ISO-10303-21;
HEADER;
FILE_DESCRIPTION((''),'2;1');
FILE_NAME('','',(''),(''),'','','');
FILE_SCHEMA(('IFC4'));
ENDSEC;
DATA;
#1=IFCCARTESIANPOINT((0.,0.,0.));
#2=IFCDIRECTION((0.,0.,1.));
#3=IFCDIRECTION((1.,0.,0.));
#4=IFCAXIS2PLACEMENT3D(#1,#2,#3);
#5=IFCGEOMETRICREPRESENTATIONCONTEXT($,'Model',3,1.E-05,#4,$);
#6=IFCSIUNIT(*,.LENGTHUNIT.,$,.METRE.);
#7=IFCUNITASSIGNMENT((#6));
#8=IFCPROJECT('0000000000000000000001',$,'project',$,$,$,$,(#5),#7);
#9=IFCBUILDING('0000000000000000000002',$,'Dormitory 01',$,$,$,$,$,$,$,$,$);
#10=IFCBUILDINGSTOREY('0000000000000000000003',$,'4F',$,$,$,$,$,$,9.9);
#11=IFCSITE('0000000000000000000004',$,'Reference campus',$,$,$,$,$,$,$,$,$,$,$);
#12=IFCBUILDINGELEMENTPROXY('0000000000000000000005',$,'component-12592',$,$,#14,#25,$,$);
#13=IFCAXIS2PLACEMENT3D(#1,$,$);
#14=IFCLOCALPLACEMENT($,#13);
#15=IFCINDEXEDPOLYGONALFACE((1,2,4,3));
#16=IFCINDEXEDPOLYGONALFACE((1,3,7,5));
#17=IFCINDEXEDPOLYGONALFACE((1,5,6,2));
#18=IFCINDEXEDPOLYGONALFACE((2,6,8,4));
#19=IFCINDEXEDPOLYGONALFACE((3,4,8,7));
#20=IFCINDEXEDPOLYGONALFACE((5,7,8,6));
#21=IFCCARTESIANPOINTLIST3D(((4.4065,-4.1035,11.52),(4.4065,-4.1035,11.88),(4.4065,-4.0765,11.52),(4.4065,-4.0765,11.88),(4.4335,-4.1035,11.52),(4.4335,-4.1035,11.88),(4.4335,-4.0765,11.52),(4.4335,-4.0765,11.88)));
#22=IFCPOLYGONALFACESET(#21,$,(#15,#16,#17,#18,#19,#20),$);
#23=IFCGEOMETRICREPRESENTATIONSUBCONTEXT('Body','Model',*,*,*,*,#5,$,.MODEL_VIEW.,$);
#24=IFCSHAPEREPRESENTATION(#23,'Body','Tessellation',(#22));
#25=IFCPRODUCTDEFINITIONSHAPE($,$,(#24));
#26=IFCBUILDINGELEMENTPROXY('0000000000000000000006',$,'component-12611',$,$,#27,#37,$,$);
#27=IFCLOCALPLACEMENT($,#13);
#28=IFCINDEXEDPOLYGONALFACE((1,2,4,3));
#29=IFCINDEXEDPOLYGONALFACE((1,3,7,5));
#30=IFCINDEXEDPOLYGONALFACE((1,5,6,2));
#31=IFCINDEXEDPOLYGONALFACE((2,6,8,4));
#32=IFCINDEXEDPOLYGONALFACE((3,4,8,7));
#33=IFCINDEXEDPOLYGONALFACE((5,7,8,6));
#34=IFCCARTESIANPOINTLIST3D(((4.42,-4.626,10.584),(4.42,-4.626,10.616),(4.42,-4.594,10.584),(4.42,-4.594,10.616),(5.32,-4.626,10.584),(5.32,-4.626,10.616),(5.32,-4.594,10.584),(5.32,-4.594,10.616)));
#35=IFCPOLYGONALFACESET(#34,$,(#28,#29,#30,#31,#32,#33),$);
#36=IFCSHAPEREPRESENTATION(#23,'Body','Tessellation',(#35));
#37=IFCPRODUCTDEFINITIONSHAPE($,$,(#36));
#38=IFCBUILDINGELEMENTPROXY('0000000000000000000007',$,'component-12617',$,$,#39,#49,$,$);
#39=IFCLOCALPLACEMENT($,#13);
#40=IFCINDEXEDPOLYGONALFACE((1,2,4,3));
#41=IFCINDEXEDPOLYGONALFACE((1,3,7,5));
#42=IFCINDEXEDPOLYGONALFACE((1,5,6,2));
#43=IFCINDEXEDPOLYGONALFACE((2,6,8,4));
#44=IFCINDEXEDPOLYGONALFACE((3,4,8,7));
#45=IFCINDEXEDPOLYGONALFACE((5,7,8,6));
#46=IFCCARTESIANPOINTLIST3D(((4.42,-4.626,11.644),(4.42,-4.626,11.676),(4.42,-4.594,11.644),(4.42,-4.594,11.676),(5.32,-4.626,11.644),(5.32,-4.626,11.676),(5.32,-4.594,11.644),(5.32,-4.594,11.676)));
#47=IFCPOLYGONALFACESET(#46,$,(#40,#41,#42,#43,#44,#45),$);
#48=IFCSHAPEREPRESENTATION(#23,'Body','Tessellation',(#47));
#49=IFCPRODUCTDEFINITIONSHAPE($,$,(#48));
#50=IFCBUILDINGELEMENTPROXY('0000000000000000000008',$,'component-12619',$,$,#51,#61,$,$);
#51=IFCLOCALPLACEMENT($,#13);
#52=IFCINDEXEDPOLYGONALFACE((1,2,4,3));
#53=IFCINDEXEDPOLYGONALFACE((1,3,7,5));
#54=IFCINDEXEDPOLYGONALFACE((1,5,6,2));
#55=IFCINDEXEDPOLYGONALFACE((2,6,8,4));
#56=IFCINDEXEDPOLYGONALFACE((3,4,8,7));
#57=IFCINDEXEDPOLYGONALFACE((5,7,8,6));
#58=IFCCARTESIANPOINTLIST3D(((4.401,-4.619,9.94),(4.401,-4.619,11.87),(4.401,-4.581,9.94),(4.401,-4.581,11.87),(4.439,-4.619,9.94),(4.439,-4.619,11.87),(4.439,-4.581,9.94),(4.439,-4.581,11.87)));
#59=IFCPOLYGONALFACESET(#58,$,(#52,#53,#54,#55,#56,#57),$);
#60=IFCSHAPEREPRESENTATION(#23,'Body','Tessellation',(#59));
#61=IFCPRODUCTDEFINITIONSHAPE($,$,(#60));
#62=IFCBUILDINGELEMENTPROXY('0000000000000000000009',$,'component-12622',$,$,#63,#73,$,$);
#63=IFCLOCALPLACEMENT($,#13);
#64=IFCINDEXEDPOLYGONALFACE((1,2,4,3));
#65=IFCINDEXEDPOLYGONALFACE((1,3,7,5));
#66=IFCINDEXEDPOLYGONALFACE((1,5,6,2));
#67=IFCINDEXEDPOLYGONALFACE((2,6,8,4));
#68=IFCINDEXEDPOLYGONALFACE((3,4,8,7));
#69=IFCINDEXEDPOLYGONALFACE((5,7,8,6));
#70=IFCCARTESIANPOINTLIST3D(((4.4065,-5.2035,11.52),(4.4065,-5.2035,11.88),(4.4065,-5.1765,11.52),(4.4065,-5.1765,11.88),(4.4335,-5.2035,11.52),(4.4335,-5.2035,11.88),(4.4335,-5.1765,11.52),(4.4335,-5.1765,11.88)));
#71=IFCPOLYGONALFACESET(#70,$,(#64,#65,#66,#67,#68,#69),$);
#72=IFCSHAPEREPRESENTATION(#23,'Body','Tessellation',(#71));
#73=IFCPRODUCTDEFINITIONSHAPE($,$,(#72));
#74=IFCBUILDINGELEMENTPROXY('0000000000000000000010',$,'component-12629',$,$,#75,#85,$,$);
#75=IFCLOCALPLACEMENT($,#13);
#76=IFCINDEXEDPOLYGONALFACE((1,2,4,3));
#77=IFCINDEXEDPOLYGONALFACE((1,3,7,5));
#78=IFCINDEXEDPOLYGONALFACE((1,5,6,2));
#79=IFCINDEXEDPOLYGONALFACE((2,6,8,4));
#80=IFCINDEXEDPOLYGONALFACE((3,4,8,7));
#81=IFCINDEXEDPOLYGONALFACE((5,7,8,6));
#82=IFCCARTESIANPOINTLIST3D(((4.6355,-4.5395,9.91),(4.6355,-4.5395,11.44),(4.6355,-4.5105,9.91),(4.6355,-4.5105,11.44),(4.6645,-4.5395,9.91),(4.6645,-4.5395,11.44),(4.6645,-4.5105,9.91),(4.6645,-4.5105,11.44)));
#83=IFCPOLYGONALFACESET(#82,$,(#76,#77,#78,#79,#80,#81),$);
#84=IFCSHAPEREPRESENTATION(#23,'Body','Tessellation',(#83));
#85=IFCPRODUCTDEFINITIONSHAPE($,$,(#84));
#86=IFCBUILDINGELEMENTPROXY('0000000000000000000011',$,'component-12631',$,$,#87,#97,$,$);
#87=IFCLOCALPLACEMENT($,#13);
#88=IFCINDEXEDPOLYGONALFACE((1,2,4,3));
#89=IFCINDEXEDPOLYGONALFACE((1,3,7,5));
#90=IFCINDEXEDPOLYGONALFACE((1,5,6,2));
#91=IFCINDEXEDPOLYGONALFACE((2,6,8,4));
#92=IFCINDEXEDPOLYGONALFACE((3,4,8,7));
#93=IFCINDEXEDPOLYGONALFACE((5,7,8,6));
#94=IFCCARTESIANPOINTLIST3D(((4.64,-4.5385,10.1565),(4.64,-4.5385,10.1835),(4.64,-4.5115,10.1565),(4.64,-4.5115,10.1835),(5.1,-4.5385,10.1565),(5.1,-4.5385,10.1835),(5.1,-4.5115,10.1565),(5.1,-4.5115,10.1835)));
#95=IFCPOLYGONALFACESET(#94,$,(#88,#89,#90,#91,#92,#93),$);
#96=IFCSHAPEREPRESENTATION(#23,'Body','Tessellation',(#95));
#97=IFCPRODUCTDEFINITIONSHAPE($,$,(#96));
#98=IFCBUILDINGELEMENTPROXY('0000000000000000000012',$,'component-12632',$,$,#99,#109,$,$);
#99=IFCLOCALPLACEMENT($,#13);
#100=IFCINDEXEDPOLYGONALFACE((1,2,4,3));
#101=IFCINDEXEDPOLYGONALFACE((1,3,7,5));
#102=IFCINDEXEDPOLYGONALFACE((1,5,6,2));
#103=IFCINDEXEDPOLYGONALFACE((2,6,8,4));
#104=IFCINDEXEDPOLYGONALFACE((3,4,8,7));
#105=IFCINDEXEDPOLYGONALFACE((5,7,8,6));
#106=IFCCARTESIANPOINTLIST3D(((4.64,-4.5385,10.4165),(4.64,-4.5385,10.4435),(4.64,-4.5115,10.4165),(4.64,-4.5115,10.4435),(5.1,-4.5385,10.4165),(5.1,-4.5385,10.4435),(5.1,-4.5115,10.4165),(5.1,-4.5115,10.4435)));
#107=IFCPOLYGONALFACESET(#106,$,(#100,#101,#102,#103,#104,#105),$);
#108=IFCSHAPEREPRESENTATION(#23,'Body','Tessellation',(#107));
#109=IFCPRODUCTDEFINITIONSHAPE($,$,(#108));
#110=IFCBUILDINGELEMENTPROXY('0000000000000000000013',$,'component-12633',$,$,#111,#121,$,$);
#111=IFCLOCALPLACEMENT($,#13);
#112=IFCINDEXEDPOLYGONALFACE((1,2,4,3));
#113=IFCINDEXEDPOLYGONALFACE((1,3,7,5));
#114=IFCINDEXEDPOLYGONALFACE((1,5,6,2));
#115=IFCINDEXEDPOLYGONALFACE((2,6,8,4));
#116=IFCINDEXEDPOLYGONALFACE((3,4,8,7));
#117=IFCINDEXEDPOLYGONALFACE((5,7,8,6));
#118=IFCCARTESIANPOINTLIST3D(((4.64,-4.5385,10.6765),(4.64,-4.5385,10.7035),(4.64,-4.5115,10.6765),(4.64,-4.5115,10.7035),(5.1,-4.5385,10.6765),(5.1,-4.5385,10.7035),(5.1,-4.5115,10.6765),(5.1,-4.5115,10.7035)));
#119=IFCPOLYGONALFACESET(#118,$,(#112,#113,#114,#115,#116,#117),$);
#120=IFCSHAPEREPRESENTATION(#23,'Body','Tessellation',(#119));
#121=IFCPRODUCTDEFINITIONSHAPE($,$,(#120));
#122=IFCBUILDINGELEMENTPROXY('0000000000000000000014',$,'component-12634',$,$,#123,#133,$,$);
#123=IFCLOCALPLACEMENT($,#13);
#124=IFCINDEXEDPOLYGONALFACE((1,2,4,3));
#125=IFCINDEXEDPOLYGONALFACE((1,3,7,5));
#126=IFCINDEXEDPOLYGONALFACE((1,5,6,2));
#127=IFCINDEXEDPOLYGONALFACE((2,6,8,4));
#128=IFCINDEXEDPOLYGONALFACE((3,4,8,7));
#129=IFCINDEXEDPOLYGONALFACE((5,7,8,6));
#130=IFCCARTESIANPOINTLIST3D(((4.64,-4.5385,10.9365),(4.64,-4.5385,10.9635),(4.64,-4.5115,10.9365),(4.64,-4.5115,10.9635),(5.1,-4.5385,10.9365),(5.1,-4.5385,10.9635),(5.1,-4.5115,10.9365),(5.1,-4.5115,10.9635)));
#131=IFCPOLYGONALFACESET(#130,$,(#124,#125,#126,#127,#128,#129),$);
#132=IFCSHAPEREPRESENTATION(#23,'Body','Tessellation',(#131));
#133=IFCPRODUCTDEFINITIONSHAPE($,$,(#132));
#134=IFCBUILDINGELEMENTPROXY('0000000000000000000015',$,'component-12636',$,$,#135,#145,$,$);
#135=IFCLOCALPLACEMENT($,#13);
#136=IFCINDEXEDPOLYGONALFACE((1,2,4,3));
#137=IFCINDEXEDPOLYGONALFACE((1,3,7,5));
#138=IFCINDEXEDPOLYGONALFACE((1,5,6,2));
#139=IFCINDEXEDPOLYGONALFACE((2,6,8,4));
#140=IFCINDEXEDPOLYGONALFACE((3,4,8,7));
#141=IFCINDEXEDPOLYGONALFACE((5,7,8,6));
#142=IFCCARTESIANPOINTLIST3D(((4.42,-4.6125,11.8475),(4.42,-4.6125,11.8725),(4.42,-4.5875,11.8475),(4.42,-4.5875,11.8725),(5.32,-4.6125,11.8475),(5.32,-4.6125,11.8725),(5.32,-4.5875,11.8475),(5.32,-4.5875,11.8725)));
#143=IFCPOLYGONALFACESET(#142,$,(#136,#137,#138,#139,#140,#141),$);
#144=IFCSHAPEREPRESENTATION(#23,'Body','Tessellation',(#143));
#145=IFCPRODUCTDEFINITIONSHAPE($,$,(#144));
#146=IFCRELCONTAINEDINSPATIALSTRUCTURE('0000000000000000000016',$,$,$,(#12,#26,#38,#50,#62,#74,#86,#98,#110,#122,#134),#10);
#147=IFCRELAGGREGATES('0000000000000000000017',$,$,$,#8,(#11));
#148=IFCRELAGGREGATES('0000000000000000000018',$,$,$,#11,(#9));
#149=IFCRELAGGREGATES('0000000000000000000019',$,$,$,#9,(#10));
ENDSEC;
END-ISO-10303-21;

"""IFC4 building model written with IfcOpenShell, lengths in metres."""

from ifc_helpers import new_model, si_unit, frame, origin, origin_with_axes, origin_2d, place, context, subcontext, project, spatial, rectangle, extrude, element, save


model = new_model("IFC4")

# Units and contexts
model_context = context("Model", 3, precision=1e-05, world=origin_with_axes())
body_context = subcontext(model_context, "Body", "Model", "MODEL_VIEW")
ifc_project = project(units=[si_unit("LENGTHUNIT", "METRE")], contexts=[model_context])

# Site, building, storey
site = spatial("IfcSite", under=ifc_project, Name="Reference campus")
building = spatial("IfcBuilding", under=site, Name="Dormitory 01")
storey = spatial("IfcBuildingStorey", under=building, Name="4F", Elevation=9.9)

# Building element proxies
proxy_1_placement = place(None, frame((4.42, -4.09, 11.52), z_axis=(0.0, 0.0, 1.0), x_axis=(1.0, 0.0, 0.0)))
element("IfcBuildingElementProxy", 1, at=proxy_1_placement, inside=storey, Name="component-12592", context=body_context, shape_type="SweptSolid", body=[
    extrude(rectangle(XDim=0.027, YDim=0.027, at=origin_2d()), origin(), (0.0, 0.0, 1.0), 0.36),
])
for number, where, z_axis, x_axis, name in (
    (2, (4.87, -4.61, 10.584), (0.0, 0.0, 1.0), (1.0, 0.0, 0.0), "component-12611"),
    (3, (4.87, -4.61, 11.644), (0.0, 0.0, 1.0), (1.0, 0.0, 0.0), "component-12617"),
):
    element("IfcBuildingElementProxy", number, at=place(None, frame(where, z_axis=z_axis, x_axis=x_axis)), inside=storey, Name=name, context=body_context, shape_type="SweptSolid", body=[
        extrude(rectangle(XDim=0.9, YDim=0.032, at=origin_2d()), origin(), (0.0, 0.0, 1.0), 0.032),
    ])
proxy_2_placement = place(None, frame((4.42, -4.6, 9.94), z_axis=(0.0, 0.0, 1.0), x_axis=(1.0, 0.0, 0.0)))
element("IfcBuildingElementProxy", 4, at=proxy_2_placement, inside=storey, Name="component-12619", context=body_context, shape_type="SweptSolid", body=[
    extrude(rectangle(XDim=0.038, YDim=0.038, at=origin_2d()), origin(), (0.0, 0.0, 1.0), 1.93),
])
proxy_3_placement = place(None, frame((4.42, -5.19, 11.52), z_axis=(0.0, 0.0, 1.0), x_axis=(1.0, 0.0, 0.0)))
element("IfcBuildingElementProxy", 5, at=proxy_3_placement, inside=storey, Name="component-12622", context=body_context, shape_type="SweptSolid", body=[
    extrude(rectangle(XDim=0.027, YDim=0.027, at=origin_2d()), origin(), (0.0, 0.0, 1.0), 0.36),
])
proxy_4_placement = place(None, frame((4.65, -4.525, 9.91), z_axis=(0.0, 0.0, 1.0), x_axis=(1.0, 0.0, 0.0)))
element("IfcBuildingElementProxy", 6, at=proxy_4_placement, inside=storey, Name="component-12629", context=body_context, shape_type="SweptSolid", body=[
    extrude(rectangle(XDim=0.029, YDim=0.029, at=origin_2d()), origin(), (0.0, 0.0, 1.0), 1.53),
])
for number, where, z_axis, x_axis, name in (
    (7, (4.87, -4.525, 10.1565), (0.0, 0.0, 1.0), (1.0, 0.0, 0.0), "component-12631"),
    (8, (4.87, -4.525, 10.4165), (0.0, 0.0, 1.0), (1.0, 0.0, 0.0), "component-12632"),
    (9, (4.87, -4.525, 10.6765), (0.0, 0.0, 1.0), (1.0, 0.0, 0.0), "component-12633"),
    (10, (4.87, -4.525, 10.9365), (0.0, 0.0, 1.0), (1.0, 0.0, 0.0), "component-12634"),
):
    element("IfcBuildingElementProxy", number, at=place(None, frame(where, z_axis=z_axis, x_axis=x_axis)), inside=storey, Name=name, context=body_context, shape_type="SweptSolid", body=[
        extrude(rectangle(XDim=0.46, YDim=0.027, at=origin_2d()), origin(), (0.0, 0.0, 1.0), 0.027),
    ])
proxy_5_placement = place(None, frame((4.87, -4.6, 11.8475), z_axis=(0.0, 0.0, 1.0), x_axis=(1.0, 0.0, 0.0)))
element("IfcBuildingElementProxy", 11, at=proxy_5_placement, inside=storey, Name="component-12636", context=body_context, shape_type="SweptSolid", body=[
    extrude(rectangle(XDim=0.9, YDim=0.025, at=origin_2d()), origin(), (0.0, 0.0, 1.0), 0.025),
])

save(model, "model.ifc")
